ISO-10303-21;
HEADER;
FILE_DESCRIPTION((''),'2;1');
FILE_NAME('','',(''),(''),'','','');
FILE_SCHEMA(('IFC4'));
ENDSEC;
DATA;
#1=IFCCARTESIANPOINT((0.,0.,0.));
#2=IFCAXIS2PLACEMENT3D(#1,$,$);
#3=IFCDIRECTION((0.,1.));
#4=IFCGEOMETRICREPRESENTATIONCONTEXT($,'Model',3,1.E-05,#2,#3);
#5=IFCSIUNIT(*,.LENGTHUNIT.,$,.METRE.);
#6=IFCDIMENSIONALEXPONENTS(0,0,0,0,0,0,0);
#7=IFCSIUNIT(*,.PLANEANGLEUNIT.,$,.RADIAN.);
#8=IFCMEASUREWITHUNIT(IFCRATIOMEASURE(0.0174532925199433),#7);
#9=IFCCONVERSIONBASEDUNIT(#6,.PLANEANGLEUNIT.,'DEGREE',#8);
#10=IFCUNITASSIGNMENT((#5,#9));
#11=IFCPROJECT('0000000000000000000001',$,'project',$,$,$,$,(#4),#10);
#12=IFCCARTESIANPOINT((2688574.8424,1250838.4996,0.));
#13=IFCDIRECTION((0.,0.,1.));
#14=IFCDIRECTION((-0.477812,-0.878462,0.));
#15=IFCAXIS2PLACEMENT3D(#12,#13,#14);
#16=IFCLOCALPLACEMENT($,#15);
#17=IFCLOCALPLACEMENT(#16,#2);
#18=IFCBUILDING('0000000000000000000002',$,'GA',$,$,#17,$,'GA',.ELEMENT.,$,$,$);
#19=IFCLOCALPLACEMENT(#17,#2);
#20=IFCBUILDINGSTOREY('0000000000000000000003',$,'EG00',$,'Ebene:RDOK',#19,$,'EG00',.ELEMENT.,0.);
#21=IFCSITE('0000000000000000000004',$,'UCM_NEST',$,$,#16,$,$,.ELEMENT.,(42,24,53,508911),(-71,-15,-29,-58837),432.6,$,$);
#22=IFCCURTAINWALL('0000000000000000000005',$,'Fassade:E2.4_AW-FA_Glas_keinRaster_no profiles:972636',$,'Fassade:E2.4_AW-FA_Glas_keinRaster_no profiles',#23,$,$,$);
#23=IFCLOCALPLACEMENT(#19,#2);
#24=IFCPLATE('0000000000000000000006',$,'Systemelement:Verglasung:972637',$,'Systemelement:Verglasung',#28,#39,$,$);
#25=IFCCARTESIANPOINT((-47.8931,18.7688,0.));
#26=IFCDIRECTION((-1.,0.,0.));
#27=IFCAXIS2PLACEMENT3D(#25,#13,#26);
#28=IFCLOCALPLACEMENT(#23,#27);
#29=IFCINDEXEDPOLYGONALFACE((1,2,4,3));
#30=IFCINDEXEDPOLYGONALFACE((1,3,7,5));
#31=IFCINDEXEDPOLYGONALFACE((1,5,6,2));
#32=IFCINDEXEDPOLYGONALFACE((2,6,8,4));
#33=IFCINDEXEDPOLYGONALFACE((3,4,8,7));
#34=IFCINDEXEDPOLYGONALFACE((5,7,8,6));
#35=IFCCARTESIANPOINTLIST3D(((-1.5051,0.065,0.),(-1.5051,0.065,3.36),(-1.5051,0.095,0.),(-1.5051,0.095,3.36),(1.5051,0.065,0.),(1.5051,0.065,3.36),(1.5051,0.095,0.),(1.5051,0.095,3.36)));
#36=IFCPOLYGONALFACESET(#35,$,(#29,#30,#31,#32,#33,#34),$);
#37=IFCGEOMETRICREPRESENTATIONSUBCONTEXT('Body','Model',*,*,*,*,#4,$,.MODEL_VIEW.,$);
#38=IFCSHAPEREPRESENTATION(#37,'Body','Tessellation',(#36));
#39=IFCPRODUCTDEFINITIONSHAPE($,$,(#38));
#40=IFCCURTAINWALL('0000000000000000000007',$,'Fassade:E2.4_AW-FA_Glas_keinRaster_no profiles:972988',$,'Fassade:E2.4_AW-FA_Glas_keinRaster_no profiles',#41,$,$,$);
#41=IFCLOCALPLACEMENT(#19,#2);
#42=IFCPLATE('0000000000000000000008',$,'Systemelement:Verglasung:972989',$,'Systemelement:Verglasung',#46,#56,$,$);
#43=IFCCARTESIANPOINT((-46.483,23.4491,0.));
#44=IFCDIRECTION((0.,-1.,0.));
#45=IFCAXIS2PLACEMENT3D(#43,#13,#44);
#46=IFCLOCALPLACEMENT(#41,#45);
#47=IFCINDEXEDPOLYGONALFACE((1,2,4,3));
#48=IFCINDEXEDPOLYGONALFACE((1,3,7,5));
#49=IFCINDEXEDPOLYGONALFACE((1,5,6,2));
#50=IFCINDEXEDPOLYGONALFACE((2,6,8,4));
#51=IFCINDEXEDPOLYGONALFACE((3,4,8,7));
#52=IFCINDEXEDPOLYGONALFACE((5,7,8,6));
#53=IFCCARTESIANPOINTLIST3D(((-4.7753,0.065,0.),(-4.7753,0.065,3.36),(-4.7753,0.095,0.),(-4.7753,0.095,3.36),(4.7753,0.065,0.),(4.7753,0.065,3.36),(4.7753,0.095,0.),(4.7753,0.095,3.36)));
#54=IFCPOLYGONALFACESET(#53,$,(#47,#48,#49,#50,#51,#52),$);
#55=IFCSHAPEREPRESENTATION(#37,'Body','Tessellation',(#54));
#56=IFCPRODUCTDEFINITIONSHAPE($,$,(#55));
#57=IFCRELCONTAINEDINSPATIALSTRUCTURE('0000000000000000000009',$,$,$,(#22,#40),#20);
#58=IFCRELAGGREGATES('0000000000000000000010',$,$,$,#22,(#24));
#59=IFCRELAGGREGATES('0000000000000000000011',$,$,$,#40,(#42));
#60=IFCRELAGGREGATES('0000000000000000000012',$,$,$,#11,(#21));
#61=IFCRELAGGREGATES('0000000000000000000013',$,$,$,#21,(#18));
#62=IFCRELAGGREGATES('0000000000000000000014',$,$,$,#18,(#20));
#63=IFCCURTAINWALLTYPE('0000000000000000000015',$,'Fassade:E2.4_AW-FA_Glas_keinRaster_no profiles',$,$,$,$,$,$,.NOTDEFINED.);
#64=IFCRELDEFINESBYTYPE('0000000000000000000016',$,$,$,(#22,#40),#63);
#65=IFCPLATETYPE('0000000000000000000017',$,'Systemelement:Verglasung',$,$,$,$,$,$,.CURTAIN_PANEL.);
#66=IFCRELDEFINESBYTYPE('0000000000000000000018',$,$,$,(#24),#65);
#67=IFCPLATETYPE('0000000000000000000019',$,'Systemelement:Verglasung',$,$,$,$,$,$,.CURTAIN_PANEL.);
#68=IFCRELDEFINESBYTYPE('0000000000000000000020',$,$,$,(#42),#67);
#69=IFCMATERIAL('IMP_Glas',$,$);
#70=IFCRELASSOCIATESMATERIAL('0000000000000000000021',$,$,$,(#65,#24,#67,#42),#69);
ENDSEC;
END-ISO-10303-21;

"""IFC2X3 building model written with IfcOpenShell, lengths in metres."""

from ifc_helpers import new_model, entity, si_unit, converted_unit, direction, frame, frame_2d, origin, place, context, subcontext, project, spatial, rectangle, extrude, source, transform, mapped, material, type_object, type_shapes, element, aggregate, save


model = new_model("IFC2X3")

# Units and contexts
model_context = context("Model", 3, precision=1e-05, world=origin(), true_north=direction((0.0, 1.0)))
body_context = subcontext(model_context, "Body", "Model", "MODEL_VIEW")
ifc_project = project(units=[si_unit("LENGTHUNIT", "METRE"), converted_unit("PLANEANGLEUNIT", "DEGREE", entity("IfcRatioMeasure", 0.0174532925199433), si_unit("PLANEANGLEUNIT", "RADIAN"), dimensions=[0, 0, 0, 0, 0, 0, 0])], contexts=[model_context])

# Site, building, storey
site_placement = place(None, frame((2688574.8424, 1250838.4996, 0.0), z_axis=(0.0, 0.0, 1.0), x_axis=(-0.477812, -0.878462, 0.0)))
site = spatial("IfcSite", under=ifc_project, at=site_placement, Name="UCM_NEST", CompositionType="ELEMENT", RefLatitude=(42, 24, 53, 508911), RefLongitude=(-71, -15, -29, -58837), RefElevation=432.6)
building_placement = place(site_placement, origin())
building = spatial("IfcBuilding", under=site, at=building_placement, Name="GA", LongName="GA", CompositionType="ELEMENT")
storey_placement = place(building_placement, origin())
storey = spatial("IfcBuildingStorey", under=building, at=storey_placement, Name="EG00", ObjectType="Ebene:RDOK", LongName="EG00", CompositionType="ELEMENT", Elevation=0.0)

# Curtain walls, plates
curtain_wall_type = type_object("IfcCurtainWallType", Name="Fassade:E2.4_AW-FA_Glas_keinRaster_no profiles", PredefinedType="NOTDEFINED")
curtain_wall_1_placement = place(storey_placement, origin())
curtain_wall_1 = element("IfcCurtainWall", 1, at=curtain_wall_1_placement, inside=storey, type_object=curtain_wall_type, Name="Fassade:E2.4_AW-FA_Glas_keinRaster_no profiles:972636", ObjectType="Fassade:E2.4_AW-FA_Glas_keinRaster_no profiles")
ifc_material_1 = material(Name="IMP_Glas")
plate_type_1 = type_object("IfcPlateType", Name="Systemelement:Verglasung", PredefinedType="CURTAIN_PANEL", material=ifc_material_1)
shared_shape_1 = source(origin(), body_context, "Body", "SweptSolid", [
    extrude(rectangle(XDim=0.03, YDim=3.0101, at=frame_2d((0.0, 0.0), x_axis=(1.0, 0.0))), frame((0.0, 0.08, 0.0), z_axis=(0.0, 0.0, 1.0), x_axis=(0.0, 1.0, 0.0)), (0.0, 0.0, 1.0), 3.36),
])
type_shapes(plate_type_1, [shared_shape_1])
plate_1_placement = place(curtain_wall_1_placement, frame((-47.8931, 18.7688, 0.0), z_axis=(0.0, 0.0, 1.0), x_axis=(-1.0, 0.0, 0.0)))
plate_1 = element("IfcPlate", 2, at=plate_1_placement, type_object=plate_type_1, material=ifc_material_1, Name="Systemelement:Verglasung:972637", ObjectType="Systemelement:Verglasung", context=body_context, shape_type="MappedRepresentation", body=[
    mapped(shared_shape_1, transform((0.0, 0.0, 0.0), scale=1.0)),
])
aggregate(curtain_wall_1, [plate_1])
curtain_wall_2_placement = place(storey_placement, origin())
curtain_wall_2 = element("IfcCurtainWall", 3, at=curtain_wall_2_placement, inside=storey, type_object=curtain_wall_type, Name="Fassade:E2.4_AW-FA_Glas_keinRaster_no profiles:972988", ObjectType="Fassade:E2.4_AW-FA_Glas_keinRaster_no profiles")
plate_type_2 = type_object("IfcPlateType", Name="Systemelement:Verglasung", PredefinedType="CURTAIN_PANEL", material=ifc_material_1)
shared_shape_2 = source(origin(), body_context, "Body", "SweptSolid", [
    extrude(rectangle(XDim=0.03, YDim=9.5506, at=frame_2d((0.0, 0.0), x_axis=(1.0, 0.0))), frame((0.0, 0.08, 0.0), z_axis=(0.0, 0.0, 1.0), x_axis=(0.0, 1.0, 0.0)), (0.0, 0.0, 1.0), 3.36),
])
type_shapes(plate_type_2, [shared_shape_2])
plate_2_placement = place(curtain_wall_2_placement, frame((-46.483, 23.4491, 0.0), z_axis=(0.0, 0.0, 1.0), x_axis=(0.0, -1.0, 0.0)))
plate_2 = element("IfcPlate", 4, at=plate_2_placement, type_object=plate_type_2, material=ifc_material_1, Name="Systemelement:Verglasung:972989", ObjectType="Systemelement:Verglasung", context=body_context, shape_type="MappedRepresentation", body=[
    mapped(shared_shape_2, transform((0.0, 0.0, 0.0), scale=1.0)),
])
aggregate(curtain_wall_2, [plate_2])

save(model, "model.ifc")
